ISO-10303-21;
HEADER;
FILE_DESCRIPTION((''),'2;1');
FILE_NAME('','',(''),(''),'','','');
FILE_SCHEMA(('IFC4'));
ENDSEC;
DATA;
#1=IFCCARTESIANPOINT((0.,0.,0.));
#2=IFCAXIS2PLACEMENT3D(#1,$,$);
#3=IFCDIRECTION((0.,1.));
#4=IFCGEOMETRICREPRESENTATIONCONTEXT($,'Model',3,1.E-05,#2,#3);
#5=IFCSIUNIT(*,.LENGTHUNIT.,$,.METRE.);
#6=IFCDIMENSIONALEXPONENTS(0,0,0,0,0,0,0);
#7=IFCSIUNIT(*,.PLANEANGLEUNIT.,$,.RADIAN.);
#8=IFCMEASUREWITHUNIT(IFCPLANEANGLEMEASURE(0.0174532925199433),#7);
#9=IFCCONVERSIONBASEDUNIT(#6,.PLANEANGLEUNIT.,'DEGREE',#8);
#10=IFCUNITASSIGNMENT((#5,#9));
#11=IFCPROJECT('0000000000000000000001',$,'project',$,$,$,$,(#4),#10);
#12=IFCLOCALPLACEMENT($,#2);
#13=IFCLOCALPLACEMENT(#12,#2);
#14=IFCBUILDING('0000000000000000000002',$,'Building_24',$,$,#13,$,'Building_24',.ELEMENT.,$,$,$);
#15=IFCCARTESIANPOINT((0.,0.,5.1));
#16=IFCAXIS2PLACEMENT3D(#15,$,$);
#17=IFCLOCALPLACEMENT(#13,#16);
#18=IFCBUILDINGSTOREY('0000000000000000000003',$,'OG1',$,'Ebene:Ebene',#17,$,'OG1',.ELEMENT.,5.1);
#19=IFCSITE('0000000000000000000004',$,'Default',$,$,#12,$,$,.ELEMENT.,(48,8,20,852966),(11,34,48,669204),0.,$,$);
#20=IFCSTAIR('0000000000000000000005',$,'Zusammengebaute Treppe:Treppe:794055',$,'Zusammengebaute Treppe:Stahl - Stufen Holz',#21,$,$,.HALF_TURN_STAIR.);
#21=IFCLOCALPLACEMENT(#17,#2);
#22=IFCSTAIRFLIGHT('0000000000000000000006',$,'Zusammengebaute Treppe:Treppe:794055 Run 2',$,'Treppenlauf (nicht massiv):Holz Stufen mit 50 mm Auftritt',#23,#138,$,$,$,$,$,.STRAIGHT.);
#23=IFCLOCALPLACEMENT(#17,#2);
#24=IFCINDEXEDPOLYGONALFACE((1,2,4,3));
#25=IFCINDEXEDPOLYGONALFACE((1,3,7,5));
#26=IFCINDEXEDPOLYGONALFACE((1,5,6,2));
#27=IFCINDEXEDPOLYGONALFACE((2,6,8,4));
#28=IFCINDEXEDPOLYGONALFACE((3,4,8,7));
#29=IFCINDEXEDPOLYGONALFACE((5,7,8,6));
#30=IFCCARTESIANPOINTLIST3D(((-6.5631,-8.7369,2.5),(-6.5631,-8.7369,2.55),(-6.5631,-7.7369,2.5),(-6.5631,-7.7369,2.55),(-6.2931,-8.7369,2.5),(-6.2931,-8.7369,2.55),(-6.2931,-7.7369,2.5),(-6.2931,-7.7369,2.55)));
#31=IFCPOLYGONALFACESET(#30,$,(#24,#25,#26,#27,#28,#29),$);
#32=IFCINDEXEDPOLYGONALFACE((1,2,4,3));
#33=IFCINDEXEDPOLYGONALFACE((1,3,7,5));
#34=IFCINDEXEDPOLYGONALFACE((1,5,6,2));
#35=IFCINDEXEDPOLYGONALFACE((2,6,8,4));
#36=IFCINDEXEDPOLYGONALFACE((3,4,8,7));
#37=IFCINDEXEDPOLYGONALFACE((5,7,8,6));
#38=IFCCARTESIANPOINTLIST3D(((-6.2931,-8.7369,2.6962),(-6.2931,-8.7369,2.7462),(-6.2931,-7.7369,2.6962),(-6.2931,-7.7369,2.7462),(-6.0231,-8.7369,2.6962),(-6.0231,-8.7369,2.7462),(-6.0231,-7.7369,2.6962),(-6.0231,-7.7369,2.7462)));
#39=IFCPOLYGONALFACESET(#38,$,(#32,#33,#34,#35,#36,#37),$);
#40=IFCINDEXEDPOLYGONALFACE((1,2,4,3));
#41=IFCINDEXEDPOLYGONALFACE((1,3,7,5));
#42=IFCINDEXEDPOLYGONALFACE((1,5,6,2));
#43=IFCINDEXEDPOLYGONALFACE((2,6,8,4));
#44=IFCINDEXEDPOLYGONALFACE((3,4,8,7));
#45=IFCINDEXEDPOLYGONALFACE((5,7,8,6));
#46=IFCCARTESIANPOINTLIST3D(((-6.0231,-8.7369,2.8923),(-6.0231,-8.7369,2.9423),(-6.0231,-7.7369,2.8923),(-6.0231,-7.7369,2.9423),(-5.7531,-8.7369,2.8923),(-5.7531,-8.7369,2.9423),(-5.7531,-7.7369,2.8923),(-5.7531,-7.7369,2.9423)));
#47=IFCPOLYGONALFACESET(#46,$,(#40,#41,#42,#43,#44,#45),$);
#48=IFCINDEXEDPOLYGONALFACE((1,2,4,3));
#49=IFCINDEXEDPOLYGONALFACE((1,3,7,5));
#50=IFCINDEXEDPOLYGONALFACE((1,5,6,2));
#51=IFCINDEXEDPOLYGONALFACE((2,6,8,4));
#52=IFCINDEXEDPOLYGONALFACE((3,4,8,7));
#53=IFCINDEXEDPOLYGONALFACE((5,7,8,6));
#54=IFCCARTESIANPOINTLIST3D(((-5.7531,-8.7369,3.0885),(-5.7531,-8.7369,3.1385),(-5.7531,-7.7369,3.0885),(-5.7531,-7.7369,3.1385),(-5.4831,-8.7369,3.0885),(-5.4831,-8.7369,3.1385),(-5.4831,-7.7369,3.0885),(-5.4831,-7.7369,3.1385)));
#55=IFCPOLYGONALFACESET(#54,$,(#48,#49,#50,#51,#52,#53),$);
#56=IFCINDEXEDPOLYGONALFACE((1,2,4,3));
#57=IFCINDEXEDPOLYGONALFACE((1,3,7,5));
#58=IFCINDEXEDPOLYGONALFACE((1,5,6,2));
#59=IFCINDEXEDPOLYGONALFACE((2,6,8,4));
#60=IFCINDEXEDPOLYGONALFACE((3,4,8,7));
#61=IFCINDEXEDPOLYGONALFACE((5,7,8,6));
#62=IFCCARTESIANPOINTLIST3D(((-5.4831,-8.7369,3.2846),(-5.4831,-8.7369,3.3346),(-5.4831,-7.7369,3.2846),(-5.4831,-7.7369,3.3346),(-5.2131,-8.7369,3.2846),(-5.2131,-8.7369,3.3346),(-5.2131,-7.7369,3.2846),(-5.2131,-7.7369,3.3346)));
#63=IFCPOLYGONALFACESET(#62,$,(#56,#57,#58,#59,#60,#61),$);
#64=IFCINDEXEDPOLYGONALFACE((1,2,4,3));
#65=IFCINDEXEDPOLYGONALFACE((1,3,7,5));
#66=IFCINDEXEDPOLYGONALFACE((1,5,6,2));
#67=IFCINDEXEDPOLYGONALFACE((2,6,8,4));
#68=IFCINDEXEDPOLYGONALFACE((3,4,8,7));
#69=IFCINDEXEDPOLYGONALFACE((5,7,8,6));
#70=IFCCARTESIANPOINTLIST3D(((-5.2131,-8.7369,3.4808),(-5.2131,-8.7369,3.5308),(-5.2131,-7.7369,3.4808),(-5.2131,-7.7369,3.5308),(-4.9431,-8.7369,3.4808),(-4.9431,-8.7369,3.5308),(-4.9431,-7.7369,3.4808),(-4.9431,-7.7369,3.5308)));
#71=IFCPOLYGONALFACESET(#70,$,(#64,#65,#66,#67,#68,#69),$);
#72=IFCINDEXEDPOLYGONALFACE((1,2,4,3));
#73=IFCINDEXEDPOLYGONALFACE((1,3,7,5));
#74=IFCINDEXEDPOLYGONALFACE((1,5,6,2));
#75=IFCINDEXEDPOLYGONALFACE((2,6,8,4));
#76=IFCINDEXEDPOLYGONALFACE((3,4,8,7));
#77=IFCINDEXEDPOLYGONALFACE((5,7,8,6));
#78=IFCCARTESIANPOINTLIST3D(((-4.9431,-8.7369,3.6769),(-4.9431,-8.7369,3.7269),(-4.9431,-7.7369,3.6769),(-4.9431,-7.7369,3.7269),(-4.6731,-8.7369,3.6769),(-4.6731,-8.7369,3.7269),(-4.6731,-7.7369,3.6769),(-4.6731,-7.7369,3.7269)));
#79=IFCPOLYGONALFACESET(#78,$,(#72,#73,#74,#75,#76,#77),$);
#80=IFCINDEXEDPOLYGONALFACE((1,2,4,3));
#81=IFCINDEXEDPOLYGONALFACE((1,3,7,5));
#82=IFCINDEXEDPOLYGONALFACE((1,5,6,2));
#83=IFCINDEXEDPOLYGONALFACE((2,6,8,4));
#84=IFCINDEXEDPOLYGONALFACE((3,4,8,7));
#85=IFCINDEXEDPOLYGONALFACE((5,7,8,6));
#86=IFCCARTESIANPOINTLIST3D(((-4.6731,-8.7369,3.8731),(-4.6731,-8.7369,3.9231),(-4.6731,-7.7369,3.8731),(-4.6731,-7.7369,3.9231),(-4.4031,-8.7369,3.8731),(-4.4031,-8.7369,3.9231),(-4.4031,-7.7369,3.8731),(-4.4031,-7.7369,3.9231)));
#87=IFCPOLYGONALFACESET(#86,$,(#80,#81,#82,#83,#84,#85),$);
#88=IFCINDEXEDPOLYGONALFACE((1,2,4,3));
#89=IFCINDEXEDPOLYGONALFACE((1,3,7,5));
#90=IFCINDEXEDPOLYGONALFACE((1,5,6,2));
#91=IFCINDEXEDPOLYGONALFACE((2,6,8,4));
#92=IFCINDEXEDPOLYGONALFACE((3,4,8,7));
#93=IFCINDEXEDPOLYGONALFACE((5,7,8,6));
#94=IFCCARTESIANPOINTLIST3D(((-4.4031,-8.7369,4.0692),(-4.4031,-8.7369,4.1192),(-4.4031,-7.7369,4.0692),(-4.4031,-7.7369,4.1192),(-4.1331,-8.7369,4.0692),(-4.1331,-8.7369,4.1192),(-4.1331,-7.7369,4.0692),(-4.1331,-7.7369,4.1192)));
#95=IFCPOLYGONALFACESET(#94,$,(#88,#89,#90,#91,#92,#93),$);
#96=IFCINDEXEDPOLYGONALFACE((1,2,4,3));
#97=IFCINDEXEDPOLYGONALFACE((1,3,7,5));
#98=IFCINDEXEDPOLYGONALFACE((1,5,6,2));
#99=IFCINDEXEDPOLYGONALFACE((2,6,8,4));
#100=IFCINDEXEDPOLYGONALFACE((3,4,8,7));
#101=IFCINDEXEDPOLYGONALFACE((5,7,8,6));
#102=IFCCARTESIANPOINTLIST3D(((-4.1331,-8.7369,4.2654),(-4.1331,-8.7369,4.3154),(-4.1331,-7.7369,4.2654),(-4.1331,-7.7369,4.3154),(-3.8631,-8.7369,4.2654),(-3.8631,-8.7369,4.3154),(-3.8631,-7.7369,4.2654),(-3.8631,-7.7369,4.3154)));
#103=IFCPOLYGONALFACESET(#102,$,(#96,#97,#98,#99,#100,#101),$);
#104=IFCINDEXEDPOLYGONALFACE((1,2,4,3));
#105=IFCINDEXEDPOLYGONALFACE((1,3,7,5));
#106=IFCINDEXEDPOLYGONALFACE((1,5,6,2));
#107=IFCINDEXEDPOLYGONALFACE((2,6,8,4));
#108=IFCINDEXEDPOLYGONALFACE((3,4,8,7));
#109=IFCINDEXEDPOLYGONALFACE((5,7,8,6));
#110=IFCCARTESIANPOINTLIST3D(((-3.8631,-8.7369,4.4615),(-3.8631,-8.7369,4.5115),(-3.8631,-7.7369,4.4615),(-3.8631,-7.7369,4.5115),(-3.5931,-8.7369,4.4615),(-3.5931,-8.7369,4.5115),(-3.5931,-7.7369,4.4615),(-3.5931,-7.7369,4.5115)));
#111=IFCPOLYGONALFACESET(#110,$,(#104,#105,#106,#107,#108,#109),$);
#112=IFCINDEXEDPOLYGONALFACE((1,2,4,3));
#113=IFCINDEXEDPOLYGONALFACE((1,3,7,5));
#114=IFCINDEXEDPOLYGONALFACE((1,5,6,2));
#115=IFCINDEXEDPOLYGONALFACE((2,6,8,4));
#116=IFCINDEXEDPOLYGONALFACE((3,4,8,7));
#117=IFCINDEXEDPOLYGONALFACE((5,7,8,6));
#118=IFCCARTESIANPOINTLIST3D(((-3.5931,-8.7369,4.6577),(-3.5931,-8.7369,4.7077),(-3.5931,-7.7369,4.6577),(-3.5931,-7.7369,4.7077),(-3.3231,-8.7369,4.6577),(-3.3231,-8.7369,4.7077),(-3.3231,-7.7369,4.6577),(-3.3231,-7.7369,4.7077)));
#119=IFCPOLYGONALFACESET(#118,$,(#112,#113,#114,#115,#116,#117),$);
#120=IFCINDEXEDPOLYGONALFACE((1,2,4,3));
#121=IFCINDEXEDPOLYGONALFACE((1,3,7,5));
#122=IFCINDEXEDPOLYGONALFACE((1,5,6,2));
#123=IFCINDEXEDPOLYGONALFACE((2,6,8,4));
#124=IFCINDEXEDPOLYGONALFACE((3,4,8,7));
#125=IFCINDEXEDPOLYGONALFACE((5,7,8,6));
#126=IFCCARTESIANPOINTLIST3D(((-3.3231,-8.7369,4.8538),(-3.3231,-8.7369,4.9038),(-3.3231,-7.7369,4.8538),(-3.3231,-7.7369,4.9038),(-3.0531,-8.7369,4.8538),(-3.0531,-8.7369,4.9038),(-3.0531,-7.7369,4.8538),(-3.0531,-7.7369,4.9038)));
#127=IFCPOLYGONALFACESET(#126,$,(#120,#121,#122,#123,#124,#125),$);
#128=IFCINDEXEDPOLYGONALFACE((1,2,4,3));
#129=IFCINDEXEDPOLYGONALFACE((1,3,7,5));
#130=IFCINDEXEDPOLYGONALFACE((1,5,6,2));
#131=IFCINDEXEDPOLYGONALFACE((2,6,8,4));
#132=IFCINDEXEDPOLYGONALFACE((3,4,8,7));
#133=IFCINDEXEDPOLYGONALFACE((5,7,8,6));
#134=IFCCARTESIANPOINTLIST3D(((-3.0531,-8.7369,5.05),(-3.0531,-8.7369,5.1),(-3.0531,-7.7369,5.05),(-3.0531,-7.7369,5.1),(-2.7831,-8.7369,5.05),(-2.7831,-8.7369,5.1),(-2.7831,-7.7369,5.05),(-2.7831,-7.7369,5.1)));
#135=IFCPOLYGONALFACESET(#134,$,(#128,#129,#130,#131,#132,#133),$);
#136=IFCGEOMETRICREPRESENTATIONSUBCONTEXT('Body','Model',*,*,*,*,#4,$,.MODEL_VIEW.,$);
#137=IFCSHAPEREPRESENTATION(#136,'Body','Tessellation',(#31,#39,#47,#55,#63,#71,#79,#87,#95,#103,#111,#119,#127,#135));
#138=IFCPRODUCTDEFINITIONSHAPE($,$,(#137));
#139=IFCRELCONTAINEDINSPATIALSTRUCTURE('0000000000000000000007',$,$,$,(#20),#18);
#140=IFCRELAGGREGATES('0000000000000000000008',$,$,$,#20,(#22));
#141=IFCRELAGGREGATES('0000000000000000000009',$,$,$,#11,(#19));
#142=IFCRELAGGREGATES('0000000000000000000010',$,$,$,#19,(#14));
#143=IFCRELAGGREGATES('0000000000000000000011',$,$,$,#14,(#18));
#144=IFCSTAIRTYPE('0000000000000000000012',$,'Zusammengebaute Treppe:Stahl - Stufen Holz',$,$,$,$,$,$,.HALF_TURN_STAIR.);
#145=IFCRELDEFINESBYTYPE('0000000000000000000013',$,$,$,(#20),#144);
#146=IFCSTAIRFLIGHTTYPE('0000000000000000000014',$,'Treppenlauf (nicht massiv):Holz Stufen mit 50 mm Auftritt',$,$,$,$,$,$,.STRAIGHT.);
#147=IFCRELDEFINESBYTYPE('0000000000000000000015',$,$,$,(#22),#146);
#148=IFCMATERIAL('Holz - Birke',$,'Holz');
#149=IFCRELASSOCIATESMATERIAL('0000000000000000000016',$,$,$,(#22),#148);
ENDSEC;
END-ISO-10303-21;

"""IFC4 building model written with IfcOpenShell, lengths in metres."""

from ifc_helpers import new_model, entity, si_unit, converted_unit, direction, frame, origin, place, context, subcontext, project, spatial, indexed_curve, outline, extrude, material, type_object, element, aggregate, save


model = new_model("IFC4")

# Units and contexts
model_context = context("Model", 3, precision=1e-05, world=origin(), true_north=direction((0.0, 1.0)))
body_context = subcontext(model_context, "Body", "Model", "MODEL_VIEW")
ifc_project = project(units=[si_unit("LENGTHUNIT", "METRE"), converted_unit("PLANEANGLEUNIT", "DEGREE", entity("IfcPlaneAngleMeasure", 0.0174532925199433), si_unit("PLANEANGLEUNIT", "RADIAN"), dimensions=[0, 0, 0, 0, 0, 0, 0])], contexts=[model_context])

# Site, building, storey
site_placement = place(None, origin())
site = spatial("IfcSite", under=ifc_project, at=site_placement, Name="Default", CompositionType="ELEMENT", RefLatitude=(48, 8, 20, 852966), RefLongitude=(11, 34, 48, 669204), RefElevation=0.0)
building_placement = place(site_placement, origin())
building = spatial("IfcBuilding", under=site, at=building_placement, Name="Building_24", LongName="Building_24", CompositionType="ELEMENT")
storey_placement = place(building_placement, frame((0.0, 0.0, 5.1)))
storey = spatial("IfcBuildingStorey", under=building, at=storey_placement, Name="OG1", ObjectType="Ebene:Ebene", LongName="OG1", CompositionType="ELEMENT", Elevation=5.1)

# Stair
stair_type = type_object("IfcStairType", Name="Zusammengebaute Treppe:Stahl - Stufen Holz", PredefinedType="HALF_TURN_STAIR")
stair_placement = place(storey_placement, origin())
stair = element("IfcStair", 1, at=stair_placement, inside=storey, type_object=stair_type, Name="Zusammengebaute Treppe:Treppe:794055", ObjectType="Zusammengebaute Treppe:Stahl - Stufen Holz", PredefinedType="HALF_TURN_STAIR")
ifc_material_1 = material(Name="Holz - Birke", Category="Holz")

# Stair flight
stair_flight_type = type_object("IfcStairFlightType", Name="Treppenlauf (nicht massiv):Holz Stufen mit 50 mm Auftritt", PredefinedType="STRAIGHT")
stair_flight_1_placement = place(stair_placement, origin())
stair_flight_1 = element("IfcStairFlight", 2, at=stair_flight_1_placement, type_object=stair_flight_type, material=ifc_material_1, Name="Zusammengebaute Treppe:Treppe:794055 Run 2", ObjectType="Treppenlauf (nicht massiv):Holz Stufen mit 50 mm Auftritt", PredefinedType="STRAIGHT", context=body_context, shape_type="SweptSolid", body=[
    extrude(outline(indexed_curve([(-0.135, -0.5), (0.135, -0.5), (0.135, 0.5), (-0.135, 0.5), (-0.135, -0.5)], self_intersect=False)), frame((-6.4281, -8.2369, 2.5), z_axis=(0.0, 0.0, 1.0), x_axis=(-1.0, 0.0, 0.0)), (0.0, 0.0, 1.0), 0.05),
    extrude(outline(indexed_curve([(-0.135, -0.5), (0.135, -0.5), (0.135, 0.5), (-0.135, 0.5), (-0.135, -0.5)], self_intersect=False)), frame((-6.1581, -8.2369, 2.6962), z_axis=(0.0, 0.0, 1.0), x_axis=(-1.0, 0.0, 0.0)), (0.0, 0.0, 1.0), 0.05),
    extrude(outline(indexed_curve([(-0.135, -0.5), (0.135, -0.5), (0.135, 0.5), (-0.135, 0.5), (-0.135, -0.5)], self_intersect=False)), frame((-5.8881, -8.2369, 2.8923), z_axis=(0.0, 0.0, 1.0), x_axis=(-1.0, 0.0, 0.0)), (0.0, 0.0, 1.0), 0.05),
    extrude(outline(indexed_curve([(-0.135, -0.5), (0.135, -0.5), (0.135, 0.5), (-0.135, 0.5), (-0.135, -0.5)], self_intersect=False)), frame((-5.6181, -8.2369, 3.0885), z_axis=(0.0, 0.0, 1.0), x_axis=(-1.0, 0.0, 0.0)), (0.0, 0.0, 1.0), 0.05),
    extrude(outline(indexed_curve([(-0.135, -0.5), (0.135, -0.5), (0.135, 0.5), (-0.135, 0.5), (-0.135, -0.5)], self_intersect=False)), frame((-5.3481, -8.2369, 3.2846), z_axis=(0.0, 0.0, 1.0), x_axis=(-1.0, 0.0, 0.0)), (0.0, 0.0, 1.0), 0.05),
    extrude(outline(indexed_curve([(-0.135, -0.5), (0.135, -0.5), (0.135, 0.5), (-0.135, 0.5), (-0.135, -0.5)], self_intersect=False)), frame((-5.0781, -8.2369, 3.4808), z_axis=(0.0, 0.0, 1.0), x_axis=(-1.0, 0.0, 0.0)), (0.0, 0.0, 1.0), 0.05),
    extrude(outline(indexed_curve([(-0.135, -0.5), (0.135, -0.5), (0.135, 0.5), (-0.135, 0.5), (-0.135, -0.5)], self_intersect=False)), frame((-4.8081, -8.2369, 3.6769), z_axis=(0.0, 0.0, 1.0), x_axis=(-1.0, 0.0, 0.0)), (0.0, 0.0, 1.0), 0.05),
    extrude(outline(indexed_curve([(-0.135, -0.5), (0.135, -0.5), (0.135, 0.5), (-0.135, 0.5), (-0.135, -0.5)], self_intersect=False)), frame((-4.5381, -8.2369, 3.8731), z_axis=(0.0, 0.0, 1.0), x_axis=(-1.0, 0.0, 0.0)), (0.0, 0.0, 1.0), 0.05),
    extrude(outline(indexed_curve([(-0.135, -0.5), (0.135, -0.5), (0.135, 0.5), (-0.135, 0.5), (-0.135, -0.5)], self_intersect=False)), frame((-4.2681, -8.2369, 4.0692), z_axis=(0.0, 0.0, 1.0), x_axis=(-1.0, 0.0, 0.0)), (0.0, 0.0, 1.0), 0.05),
    extrude(outline(indexed_curve([(-0.135, -0.5), (0.135, -0.5), (0.135, 0.5), (-0.135, 0.5), (-0.135, -0.5)], self_intersect=False)), frame((-3.9981, -8.2369, 4.2654), z_axis=(0.0, 0.0, 1.0), x_axis=(-1.0, 0.0, 0.0)), (0.0, 0.0, 1.0), 0.05),
    extrude(outline(indexed_curve([(-0.135, -0.5), (0.135, -0.5), (0.135, 0.5), (-0.135, 0.5), (-0.135, -0.5)], self_intersect=False)), frame((-3.7281, -8.2369, 4.4615), z_axis=(0.0, 0.0, 1.0), x_axis=(-1.0, 0.0, 0.0)), (0.0, 0.0, 1.0), 0.05),
    extrude(outline(indexed_curve([(-0.135, -0.5), (0.135, -0.5), (0.135, 0.5), (-0.135, 0.5), (-0.135, -0.5)], self_intersect=False)), frame((-3.4581, -8.2369, 4.6577), z_axis=(0.0, 0.0, 1.0), x_axis=(-1.0, 0.0, 0.0)), (0.0, 0.0, 1.0), 0.05),
    extrude(outline(indexed_curve([(-0.135, -0.5), (0.135, -0.5), (0.135, 0.5), (-0.135, 0.5), (-0.135, -0.5)], self_intersect=False)), frame((-3.1881, -8.2369, 4.8538), z_axis=(0.0, 0.0, 1.0), x_axis=(-1.0, 0.0, 0.0)), (0.0, 0.0, 1.0), 0.05),
    extrude(outline(indexed_curve([(-0.135, -0.5), (0.135, -0.5), (0.135, 0.5), (-0.135, 0.5), (-0.135, -0.5)], self_intersect=False)), frame((-2.9181, -8.2369, 5.05), z_axis=(0.0, 0.0, 1.0), x_axis=(-1.0, 0.0, 0.0)), (0.0, 0.0, 1.0), 0.05),
])
aggregate(stair, [stair_flight_1])

save(model, "model.ifc")
